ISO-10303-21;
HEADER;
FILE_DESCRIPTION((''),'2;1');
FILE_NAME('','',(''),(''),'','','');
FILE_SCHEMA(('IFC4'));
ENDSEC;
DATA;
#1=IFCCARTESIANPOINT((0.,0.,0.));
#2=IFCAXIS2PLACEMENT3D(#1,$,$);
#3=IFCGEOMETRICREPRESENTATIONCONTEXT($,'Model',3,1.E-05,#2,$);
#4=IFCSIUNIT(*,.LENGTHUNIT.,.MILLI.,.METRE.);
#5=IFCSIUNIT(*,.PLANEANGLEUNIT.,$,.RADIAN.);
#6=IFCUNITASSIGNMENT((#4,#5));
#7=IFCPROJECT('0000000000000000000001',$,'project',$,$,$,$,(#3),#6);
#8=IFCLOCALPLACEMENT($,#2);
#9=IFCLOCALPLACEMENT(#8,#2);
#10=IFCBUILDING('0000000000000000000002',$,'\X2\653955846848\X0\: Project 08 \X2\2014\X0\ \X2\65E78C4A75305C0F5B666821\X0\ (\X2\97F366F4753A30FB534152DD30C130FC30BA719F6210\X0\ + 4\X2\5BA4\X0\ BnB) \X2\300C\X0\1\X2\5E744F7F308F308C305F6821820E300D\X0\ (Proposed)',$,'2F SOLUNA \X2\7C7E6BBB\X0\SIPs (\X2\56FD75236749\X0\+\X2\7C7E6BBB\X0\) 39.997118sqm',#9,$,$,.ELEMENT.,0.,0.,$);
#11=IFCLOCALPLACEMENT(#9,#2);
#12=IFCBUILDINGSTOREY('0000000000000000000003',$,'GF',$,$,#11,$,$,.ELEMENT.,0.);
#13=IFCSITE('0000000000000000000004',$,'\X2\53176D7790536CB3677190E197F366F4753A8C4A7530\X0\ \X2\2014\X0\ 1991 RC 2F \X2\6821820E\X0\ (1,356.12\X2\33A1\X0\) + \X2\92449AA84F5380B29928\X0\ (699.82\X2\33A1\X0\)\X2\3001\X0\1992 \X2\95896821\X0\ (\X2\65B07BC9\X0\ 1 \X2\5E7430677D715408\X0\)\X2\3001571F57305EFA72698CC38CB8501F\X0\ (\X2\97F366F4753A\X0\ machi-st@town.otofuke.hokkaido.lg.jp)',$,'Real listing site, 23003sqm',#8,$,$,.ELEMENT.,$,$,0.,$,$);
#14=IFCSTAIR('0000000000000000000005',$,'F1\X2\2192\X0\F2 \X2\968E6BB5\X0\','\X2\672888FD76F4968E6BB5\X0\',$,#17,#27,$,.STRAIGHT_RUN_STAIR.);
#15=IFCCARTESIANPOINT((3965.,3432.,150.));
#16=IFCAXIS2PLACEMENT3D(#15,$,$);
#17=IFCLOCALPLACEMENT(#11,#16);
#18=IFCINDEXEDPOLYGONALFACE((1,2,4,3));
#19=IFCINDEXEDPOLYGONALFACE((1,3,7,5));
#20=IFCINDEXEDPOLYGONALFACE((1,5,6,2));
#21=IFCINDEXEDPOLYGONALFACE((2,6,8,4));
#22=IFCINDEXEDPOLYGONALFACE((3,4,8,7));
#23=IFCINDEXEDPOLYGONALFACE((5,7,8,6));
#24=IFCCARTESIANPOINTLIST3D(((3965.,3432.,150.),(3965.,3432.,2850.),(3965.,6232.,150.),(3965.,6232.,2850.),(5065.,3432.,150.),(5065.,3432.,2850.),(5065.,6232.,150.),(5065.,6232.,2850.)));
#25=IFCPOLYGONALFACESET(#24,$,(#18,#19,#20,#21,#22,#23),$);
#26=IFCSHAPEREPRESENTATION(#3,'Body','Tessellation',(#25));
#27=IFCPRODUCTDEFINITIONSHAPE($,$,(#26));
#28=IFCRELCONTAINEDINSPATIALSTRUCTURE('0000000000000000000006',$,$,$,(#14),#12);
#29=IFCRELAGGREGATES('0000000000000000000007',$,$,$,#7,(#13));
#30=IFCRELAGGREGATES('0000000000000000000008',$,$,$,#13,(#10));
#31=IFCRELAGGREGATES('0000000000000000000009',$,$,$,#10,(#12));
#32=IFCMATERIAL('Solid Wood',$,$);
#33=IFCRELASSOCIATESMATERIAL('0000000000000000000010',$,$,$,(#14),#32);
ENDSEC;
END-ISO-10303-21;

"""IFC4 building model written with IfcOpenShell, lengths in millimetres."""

from ifc_helpers import new_model, si_unit, frame, frame_2d, origin, place, context, project, spatial, rectangle, extrude, material, element, save


model = new_model("IFC4")

# Units and contexts
model_context = context("Model", 3, precision=1e-05, world=origin())
ifc_project = project(units=[si_unit("LENGTHUNIT", "METRE", prefix="MILLI"), si_unit("PLANEANGLEUNIT", "RADIAN")], contexts=[model_context])

# Site, building, storey
site_placement = place(None, origin())
site = spatial("IfcSite", under=ifc_project, at=site_placement, Name="北海道河東郡音更町豊田 — 1991 RC 2F 校舎 (1,356.12㎡) + 鉄骨体育館 (699.82㎡)、1992 閉校 (新築 1 年で統合)、土地建物賃貸借 (音更町 machi-st@town.otofuke.hokkaido.lg.jp)", ObjectType="Real listing site, 23003sqm", CompositionType="ELEMENT", RefElevation=0.0)
building_placement = place(site_placement, origin())
building = spatial("IfcBuilding", under=site, at=building_placement, Name="改善案: Project 08 — 旧豊田小学校 (音更町・十勝チーズ熟成 + 4室 BnB) 「1年使われた校舎」 (Proposed)", ObjectType="2F SOLUNA 籾殻SIPs (国産杉+籾殻) 39.997118sqm", CompositionType="ELEMENT", ElevationOfRefHeight=0.0, ElevationOfTerrain=0.0)
storey_placement = place(building_placement, origin())
storey = spatial("IfcBuildingStorey", under=building, at=storey_placement, Name="GF", CompositionType="ELEMENT", Elevation=0.0)

# Shared definitions
ifc_material_1 = material(Name="Solid Wood")

# Stair
stair_placement = place(storey_placement, frame((3965.0, 3432.0, 150.0)))
element("IfcStair", 1, at=stair_placement, inside=storey, material=ifc_material_1, Name="F1→F2 階段", Description="木製直階段", PredefinedType="STRAIGHT_RUN_STAIR", context=model_context, shape_type="SweptSolid", body=[
    extrude(rectangle(XDim=1100.0, YDim=2800.0, at=frame_2d((550.0, 1400.0))), frame((3965.0, 3432.0, 150.0)), (0.0, 0.0, 1.0), 2700.0),
])

save(model, "model.ifc")
